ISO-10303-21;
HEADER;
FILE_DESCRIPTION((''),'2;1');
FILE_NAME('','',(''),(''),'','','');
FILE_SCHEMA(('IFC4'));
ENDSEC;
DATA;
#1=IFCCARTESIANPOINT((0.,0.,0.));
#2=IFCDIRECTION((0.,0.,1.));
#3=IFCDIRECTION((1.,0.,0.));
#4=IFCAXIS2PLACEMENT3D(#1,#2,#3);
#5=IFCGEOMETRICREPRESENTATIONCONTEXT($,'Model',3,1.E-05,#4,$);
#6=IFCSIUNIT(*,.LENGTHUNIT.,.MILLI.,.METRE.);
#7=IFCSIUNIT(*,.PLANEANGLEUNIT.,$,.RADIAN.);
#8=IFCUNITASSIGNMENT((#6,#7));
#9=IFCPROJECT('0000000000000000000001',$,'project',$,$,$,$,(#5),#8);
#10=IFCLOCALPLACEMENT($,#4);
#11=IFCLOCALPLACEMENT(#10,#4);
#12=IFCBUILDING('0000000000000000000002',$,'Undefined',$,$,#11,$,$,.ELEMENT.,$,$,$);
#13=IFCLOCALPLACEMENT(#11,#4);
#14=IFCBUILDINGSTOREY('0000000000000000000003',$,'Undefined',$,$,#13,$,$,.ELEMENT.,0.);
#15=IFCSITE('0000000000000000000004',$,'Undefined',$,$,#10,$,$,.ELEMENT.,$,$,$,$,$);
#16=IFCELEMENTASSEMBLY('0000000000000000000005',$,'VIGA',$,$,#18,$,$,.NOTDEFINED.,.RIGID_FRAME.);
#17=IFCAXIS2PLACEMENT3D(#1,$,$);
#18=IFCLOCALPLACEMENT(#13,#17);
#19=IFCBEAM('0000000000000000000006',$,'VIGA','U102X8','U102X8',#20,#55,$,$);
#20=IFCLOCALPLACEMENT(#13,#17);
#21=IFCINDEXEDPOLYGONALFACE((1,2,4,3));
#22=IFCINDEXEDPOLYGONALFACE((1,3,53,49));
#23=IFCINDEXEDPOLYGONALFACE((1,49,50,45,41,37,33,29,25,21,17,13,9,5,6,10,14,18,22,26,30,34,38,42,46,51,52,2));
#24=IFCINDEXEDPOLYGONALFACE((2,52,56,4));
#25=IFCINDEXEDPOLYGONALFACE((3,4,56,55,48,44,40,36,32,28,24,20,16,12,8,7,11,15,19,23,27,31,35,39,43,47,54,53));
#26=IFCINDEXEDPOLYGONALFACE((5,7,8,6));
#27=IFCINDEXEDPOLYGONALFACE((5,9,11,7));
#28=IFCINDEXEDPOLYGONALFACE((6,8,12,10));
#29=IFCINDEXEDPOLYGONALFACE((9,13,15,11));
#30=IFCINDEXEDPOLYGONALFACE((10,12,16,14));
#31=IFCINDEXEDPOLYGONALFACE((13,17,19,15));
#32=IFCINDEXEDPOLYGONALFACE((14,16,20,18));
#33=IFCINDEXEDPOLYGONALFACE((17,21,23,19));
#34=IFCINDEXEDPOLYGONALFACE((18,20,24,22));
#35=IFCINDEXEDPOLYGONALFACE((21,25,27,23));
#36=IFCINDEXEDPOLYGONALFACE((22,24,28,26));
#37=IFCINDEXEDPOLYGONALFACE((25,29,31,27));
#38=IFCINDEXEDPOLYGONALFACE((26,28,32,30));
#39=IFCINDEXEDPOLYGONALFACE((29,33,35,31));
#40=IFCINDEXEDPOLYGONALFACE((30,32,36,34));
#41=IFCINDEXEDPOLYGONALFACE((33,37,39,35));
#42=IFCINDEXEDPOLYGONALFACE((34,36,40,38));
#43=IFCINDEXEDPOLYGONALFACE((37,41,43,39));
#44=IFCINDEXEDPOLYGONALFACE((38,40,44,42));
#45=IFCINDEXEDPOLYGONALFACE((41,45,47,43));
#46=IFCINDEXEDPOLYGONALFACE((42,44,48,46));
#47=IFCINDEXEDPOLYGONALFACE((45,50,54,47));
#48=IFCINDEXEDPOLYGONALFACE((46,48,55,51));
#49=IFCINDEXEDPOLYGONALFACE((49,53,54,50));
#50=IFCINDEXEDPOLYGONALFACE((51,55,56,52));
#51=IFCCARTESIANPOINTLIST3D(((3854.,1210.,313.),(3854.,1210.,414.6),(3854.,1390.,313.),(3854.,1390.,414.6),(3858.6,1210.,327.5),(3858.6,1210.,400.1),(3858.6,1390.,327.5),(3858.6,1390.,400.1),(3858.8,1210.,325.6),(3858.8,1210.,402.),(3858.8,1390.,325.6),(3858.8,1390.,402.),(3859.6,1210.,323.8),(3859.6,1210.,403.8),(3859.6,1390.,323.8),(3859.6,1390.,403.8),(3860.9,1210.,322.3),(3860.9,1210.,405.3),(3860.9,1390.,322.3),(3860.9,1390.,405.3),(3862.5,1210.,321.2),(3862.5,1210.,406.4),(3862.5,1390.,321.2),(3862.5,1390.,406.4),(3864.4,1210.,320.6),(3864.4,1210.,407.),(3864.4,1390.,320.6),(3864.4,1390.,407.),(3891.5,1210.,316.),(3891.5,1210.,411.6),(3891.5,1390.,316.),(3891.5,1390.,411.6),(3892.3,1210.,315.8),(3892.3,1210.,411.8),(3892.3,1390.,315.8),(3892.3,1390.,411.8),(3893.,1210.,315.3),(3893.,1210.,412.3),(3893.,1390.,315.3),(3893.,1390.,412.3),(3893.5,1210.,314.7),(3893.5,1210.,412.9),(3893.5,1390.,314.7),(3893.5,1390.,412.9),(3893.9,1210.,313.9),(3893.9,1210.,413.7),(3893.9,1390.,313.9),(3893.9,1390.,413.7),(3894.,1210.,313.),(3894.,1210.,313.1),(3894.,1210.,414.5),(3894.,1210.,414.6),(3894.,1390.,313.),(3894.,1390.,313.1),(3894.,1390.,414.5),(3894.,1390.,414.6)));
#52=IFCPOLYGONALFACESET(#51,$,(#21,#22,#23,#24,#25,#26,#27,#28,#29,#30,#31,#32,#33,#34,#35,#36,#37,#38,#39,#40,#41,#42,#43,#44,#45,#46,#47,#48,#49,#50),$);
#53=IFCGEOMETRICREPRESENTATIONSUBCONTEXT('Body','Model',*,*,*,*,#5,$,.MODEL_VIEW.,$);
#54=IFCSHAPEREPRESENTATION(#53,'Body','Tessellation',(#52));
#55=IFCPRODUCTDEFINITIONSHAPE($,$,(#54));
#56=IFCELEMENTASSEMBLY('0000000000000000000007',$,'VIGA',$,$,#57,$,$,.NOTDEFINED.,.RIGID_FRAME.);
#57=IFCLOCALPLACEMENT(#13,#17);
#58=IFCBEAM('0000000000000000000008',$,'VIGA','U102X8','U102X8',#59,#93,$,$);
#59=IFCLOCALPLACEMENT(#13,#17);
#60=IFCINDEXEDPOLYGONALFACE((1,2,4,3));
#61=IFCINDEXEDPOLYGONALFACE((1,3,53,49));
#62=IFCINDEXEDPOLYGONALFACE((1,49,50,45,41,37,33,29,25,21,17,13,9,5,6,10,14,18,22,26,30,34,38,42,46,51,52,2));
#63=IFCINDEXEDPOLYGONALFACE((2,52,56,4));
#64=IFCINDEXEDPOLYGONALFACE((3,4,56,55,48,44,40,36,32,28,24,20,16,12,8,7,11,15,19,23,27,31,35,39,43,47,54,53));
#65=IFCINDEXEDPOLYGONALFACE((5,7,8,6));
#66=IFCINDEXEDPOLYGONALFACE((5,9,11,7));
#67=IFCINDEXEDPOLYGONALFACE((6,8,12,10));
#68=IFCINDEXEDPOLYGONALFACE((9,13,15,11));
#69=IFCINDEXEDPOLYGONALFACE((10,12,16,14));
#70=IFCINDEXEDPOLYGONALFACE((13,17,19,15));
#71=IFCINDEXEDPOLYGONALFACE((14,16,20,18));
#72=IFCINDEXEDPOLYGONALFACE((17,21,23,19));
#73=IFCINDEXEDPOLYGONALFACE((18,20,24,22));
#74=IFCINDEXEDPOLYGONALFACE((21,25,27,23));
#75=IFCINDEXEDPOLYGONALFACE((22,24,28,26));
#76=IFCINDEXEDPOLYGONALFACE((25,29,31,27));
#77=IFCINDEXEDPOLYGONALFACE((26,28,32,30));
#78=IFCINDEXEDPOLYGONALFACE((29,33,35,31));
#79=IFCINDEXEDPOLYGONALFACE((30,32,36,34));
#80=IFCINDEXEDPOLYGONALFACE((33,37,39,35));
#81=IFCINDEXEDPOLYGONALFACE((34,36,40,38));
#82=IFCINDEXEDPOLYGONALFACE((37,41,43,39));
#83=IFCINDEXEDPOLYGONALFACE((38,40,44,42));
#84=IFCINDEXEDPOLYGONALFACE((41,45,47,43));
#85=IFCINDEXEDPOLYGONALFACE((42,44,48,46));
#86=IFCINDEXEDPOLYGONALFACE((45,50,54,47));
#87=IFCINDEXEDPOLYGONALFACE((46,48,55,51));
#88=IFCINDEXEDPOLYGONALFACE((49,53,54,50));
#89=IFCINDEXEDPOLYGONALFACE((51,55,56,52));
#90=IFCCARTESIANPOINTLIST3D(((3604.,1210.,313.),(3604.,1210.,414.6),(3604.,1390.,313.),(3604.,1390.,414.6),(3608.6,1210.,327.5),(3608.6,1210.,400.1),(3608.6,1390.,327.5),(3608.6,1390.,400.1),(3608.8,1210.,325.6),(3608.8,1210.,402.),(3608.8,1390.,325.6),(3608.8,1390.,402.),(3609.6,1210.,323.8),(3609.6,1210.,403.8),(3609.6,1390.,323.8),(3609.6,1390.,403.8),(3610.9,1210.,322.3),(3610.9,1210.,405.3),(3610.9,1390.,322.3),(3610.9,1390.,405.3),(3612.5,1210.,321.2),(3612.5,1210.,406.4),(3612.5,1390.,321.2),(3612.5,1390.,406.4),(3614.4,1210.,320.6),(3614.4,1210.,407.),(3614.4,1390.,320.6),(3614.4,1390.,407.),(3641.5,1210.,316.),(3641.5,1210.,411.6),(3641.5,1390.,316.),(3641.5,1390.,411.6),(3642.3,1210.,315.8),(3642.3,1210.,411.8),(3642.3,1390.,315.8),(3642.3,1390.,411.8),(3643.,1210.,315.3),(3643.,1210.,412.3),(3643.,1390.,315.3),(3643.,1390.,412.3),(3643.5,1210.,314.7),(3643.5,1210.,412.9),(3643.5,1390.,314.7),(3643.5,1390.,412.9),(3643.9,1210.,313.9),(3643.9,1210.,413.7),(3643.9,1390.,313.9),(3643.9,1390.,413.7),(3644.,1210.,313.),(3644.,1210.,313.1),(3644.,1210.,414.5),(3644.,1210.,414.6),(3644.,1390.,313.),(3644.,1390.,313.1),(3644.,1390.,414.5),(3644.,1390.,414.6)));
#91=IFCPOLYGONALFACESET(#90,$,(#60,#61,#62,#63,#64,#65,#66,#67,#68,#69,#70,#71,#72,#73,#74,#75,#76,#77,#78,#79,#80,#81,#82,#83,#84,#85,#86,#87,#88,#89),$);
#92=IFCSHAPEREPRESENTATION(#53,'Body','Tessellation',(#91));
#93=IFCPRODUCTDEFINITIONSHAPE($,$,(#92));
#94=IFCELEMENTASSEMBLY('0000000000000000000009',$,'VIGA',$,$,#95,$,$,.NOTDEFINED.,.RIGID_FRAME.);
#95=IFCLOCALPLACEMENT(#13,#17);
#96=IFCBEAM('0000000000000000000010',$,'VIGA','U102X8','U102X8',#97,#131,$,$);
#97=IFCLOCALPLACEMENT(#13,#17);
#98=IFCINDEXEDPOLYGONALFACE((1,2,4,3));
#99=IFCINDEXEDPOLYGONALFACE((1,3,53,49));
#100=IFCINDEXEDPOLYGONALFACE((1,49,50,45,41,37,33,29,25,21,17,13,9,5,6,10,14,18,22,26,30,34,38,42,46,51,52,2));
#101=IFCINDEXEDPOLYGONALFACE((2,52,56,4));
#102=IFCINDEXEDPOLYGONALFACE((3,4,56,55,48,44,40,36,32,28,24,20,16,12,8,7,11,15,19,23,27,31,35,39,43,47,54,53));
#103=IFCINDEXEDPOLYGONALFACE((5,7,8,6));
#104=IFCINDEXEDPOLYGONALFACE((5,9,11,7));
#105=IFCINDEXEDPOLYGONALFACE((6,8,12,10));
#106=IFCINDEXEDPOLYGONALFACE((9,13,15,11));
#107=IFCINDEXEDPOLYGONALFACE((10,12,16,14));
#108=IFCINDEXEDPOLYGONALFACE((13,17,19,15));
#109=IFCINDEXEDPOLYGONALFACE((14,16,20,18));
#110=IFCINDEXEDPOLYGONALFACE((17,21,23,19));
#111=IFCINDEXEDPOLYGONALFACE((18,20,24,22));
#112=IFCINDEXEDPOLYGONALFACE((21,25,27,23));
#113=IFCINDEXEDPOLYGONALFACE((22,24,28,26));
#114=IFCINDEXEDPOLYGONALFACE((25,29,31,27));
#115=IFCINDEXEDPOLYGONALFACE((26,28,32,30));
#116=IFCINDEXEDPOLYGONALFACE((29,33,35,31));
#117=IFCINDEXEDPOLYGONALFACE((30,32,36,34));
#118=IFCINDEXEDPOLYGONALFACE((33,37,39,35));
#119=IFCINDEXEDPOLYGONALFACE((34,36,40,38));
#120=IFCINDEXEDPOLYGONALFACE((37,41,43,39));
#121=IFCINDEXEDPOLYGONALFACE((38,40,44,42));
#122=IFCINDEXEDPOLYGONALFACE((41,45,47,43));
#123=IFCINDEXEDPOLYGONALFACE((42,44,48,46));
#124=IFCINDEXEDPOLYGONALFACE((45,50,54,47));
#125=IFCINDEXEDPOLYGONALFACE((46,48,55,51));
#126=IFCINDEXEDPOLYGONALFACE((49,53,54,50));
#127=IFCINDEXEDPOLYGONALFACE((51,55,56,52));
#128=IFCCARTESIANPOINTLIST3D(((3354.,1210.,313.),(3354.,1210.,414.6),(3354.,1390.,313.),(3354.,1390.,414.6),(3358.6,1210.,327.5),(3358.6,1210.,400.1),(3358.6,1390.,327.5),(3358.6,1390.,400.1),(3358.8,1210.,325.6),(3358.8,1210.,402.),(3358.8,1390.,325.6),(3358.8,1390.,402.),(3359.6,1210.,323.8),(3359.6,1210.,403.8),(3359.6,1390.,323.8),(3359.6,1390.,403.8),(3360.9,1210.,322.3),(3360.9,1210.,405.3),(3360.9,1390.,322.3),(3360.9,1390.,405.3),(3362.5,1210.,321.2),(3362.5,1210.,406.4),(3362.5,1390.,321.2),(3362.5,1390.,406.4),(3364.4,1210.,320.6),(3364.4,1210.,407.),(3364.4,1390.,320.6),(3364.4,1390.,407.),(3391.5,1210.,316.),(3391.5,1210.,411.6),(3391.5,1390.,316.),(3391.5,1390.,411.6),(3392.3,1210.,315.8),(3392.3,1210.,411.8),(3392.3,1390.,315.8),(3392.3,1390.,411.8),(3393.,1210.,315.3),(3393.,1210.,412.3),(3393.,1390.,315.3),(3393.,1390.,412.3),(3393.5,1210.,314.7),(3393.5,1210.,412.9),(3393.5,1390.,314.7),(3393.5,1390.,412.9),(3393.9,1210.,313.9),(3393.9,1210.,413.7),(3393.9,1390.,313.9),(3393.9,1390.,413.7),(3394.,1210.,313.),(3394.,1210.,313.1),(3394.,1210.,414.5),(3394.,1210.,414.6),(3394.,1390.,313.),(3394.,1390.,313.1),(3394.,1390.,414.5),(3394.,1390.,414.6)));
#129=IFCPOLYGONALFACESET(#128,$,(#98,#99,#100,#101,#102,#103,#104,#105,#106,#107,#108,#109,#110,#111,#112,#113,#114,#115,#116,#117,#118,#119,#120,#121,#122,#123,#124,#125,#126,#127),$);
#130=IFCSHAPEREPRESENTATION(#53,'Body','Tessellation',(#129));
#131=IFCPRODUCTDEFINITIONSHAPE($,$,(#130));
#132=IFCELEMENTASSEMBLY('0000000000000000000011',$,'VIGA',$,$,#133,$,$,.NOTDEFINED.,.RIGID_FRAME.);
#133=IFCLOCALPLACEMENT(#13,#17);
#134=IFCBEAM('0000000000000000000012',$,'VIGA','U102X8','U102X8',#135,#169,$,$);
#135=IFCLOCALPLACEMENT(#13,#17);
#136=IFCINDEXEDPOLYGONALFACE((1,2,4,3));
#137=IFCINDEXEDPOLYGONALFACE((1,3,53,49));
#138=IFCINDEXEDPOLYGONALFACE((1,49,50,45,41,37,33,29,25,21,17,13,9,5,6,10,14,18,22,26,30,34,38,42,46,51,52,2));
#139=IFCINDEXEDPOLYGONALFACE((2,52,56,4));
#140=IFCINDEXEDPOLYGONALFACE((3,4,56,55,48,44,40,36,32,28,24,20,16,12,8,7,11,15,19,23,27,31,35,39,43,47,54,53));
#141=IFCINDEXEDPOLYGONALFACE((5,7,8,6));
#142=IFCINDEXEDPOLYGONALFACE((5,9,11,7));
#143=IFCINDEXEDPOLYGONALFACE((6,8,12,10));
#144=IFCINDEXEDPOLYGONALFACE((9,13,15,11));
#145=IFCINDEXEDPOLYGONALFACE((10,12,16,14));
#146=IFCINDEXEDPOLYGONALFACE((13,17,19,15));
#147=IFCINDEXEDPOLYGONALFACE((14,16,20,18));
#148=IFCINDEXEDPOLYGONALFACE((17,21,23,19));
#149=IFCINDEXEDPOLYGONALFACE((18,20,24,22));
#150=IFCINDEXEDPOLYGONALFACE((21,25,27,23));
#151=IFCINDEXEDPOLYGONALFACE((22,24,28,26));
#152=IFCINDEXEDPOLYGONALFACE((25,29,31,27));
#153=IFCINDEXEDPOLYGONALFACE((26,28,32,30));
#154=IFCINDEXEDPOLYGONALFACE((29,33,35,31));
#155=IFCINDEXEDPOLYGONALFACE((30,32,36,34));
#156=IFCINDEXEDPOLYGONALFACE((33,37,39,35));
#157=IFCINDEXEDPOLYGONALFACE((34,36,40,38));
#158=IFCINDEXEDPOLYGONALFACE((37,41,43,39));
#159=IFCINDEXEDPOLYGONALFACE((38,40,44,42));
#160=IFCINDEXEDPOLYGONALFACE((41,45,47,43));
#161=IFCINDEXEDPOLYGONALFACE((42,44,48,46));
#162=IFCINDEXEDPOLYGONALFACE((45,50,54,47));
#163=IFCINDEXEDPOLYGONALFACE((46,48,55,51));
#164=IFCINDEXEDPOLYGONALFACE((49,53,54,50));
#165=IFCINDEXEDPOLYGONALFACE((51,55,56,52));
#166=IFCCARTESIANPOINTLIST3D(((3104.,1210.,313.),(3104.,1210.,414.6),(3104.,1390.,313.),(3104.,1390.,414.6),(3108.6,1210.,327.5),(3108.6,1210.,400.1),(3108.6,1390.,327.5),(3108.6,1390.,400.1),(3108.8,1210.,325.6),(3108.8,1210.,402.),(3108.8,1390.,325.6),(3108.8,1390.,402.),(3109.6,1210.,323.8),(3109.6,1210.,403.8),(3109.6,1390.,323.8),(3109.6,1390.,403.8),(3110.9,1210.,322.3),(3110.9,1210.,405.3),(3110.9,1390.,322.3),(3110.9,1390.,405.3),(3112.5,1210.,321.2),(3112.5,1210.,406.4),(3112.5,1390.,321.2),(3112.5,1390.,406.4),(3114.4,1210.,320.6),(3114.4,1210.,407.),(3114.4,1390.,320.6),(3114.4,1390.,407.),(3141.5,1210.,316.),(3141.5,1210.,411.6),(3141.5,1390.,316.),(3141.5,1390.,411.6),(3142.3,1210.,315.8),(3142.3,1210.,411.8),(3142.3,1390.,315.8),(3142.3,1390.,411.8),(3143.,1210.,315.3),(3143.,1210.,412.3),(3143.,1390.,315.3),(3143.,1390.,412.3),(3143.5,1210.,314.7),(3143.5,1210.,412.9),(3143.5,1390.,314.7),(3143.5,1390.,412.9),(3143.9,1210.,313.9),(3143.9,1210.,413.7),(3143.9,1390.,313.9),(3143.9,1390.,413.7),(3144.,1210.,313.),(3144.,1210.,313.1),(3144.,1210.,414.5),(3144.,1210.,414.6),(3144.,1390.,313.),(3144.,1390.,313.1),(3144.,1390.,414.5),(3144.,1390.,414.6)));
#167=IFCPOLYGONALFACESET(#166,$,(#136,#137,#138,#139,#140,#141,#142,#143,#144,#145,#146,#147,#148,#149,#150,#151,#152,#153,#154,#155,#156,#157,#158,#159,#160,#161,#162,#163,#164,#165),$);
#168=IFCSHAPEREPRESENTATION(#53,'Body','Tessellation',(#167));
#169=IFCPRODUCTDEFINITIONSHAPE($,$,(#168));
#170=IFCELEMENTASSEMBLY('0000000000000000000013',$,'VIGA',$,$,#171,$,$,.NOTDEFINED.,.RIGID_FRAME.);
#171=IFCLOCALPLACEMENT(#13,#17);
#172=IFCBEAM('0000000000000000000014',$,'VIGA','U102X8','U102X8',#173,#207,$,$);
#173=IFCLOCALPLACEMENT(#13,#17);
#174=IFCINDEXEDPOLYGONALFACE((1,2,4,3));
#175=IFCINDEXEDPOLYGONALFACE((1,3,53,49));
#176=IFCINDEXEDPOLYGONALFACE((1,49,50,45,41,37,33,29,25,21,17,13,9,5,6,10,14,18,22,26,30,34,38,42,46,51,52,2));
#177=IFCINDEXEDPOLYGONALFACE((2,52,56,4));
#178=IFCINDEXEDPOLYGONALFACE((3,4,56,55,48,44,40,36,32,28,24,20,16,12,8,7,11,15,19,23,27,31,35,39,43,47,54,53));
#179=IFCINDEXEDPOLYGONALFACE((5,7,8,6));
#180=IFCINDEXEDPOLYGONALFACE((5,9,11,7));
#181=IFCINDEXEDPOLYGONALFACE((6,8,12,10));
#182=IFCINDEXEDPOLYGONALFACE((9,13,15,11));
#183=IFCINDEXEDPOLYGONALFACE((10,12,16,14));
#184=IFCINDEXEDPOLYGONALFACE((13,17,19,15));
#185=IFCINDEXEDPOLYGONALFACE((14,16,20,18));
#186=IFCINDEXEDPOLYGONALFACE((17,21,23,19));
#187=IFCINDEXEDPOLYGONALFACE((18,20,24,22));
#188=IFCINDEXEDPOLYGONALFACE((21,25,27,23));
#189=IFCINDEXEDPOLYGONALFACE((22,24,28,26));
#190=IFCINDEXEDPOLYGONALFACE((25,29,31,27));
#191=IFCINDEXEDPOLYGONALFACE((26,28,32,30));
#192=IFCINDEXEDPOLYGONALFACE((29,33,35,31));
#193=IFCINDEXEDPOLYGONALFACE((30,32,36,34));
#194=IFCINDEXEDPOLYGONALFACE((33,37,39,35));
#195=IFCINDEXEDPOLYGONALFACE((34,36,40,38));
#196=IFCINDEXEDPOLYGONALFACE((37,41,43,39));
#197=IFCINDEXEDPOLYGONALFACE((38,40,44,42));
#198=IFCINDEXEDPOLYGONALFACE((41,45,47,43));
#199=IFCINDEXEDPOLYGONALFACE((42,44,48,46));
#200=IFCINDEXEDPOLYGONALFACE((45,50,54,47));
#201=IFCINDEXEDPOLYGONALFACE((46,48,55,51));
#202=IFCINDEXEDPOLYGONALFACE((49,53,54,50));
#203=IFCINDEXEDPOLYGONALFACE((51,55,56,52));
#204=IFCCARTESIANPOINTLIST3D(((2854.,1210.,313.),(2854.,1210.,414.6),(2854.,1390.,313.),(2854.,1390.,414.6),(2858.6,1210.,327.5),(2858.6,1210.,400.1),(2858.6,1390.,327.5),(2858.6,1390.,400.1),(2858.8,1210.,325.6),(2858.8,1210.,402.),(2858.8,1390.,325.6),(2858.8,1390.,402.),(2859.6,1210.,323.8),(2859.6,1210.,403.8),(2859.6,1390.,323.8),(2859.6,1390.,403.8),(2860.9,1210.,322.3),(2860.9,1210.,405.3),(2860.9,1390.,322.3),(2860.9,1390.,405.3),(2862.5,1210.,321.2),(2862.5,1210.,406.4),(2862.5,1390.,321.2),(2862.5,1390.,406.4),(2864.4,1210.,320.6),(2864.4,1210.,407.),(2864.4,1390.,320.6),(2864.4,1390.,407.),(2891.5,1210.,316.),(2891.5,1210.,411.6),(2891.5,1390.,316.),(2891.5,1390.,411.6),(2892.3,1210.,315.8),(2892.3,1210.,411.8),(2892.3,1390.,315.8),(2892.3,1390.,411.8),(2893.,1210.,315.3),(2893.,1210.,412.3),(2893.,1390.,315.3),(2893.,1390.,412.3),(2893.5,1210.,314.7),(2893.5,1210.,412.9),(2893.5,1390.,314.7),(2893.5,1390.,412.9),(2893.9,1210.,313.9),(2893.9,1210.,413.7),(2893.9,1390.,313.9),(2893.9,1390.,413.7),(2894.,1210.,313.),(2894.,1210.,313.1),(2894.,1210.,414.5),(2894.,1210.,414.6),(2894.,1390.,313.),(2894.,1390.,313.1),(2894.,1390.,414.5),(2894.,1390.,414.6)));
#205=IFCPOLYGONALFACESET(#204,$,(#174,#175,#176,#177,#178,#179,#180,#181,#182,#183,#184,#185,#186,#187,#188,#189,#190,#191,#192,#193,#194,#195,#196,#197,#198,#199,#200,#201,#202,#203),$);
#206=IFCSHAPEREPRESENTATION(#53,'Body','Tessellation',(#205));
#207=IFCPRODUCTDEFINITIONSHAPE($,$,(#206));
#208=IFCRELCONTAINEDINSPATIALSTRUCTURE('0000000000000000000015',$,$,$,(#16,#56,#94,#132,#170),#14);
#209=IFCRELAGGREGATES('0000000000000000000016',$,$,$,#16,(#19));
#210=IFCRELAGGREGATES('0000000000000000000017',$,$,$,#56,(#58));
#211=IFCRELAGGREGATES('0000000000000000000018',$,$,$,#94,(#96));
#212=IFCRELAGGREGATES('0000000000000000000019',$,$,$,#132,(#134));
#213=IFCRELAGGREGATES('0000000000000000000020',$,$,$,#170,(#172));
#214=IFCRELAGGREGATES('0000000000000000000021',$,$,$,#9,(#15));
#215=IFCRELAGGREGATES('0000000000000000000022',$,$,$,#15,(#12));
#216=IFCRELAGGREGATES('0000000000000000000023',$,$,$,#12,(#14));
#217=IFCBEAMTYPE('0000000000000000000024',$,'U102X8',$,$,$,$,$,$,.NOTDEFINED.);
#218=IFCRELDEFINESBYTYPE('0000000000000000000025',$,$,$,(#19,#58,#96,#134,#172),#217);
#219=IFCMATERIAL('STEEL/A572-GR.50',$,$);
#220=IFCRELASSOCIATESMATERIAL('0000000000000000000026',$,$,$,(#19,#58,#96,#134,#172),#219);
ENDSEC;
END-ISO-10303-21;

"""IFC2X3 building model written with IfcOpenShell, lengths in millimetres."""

from ifc_helpers import new_model, si_unit, frame, origin_with_axes, origin_2d_with_axis, place, context, subcontext, project, spatial, u_section, extrude, material, type_object, element, aggregate, save


model = new_model("IFC2X3")

# Units and contexts
model_context = context("Model", 3, precision=1e-05, world=origin_with_axes())
body_context = subcontext(model_context, "Body", "Model", "MODEL_VIEW")
ifc_project = project(units=[si_unit("LENGTHUNIT", "METRE", prefix="MILLI"), si_unit("PLANEANGLEUNIT", "RADIAN")], contexts=[model_context])

# Site, building, storey
site_placement = place(None, origin_with_axes())
site = spatial("IfcSite", under=ifc_project, at=site_placement, Name="Undefined", CompositionType="ELEMENT")
building_placement = place(site_placement, origin_with_axes())
building = spatial("IfcBuilding", under=site, at=building_placement, Name="Undefined", CompositionType="ELEMENT")
storey_placement = place(building_placement, origin_with_axes())
storey = spatial("IfcBuildingStorey", under=building, at=storey_placement, Name="Undefined", CompositionType="ELEMENT", Elevation=0.0)

# Element assemblies, beams
assembly_1_placement = place(storey_placement, origin_with_axes())
assembly_1 = element("IfcElementAssembly", 1, at=assembly_1_placement, inside=storey, Name="VIGA", AssemblyPlace="NOTDEFINED", PredefinedType="RIGID_FRAME")
ifc_material = material(Name="STEEL/A572-GR.50")
beam_type = type_object("IfcBeamType", Name="U102X8", PredefinedType="NOTDEFINED")
beam_1_placement = place(assembly_1_placement, frame((3874.0, 1210.0, 363.8), z_axis=(0.0, 0.0, 1.0), x_axis=(0.0, 1.0, 0.0)))
beam_1 = element("IfcBeam", 2, at=beam_1_placement, type_object=beam_type, material=ifc_material, Name="VIGA", Description="U102X8", ObjectType="U102X8", context=body_context, shape_type="SweptSolid", body=[
    extrude(u_section(Depth=101.6, FlangeWidth=40.0, WebThickness=4.6, FlangeThickness=6.0, FilletRadius=7.0, EdgeRadius=3.0, FlangeSlope=0.16839, at=origin_2d_with_axis()), frame((180.0, 0.0, 0.0), z_axis=(-1.0, 0.0, 0.0), x_axis=(0.0, -1.0, 0.0)), (0.0, 0.0, 1.0), 180.0),
])
aggregate(assembly_1, [beam_1])
assembly_2_placement = place(storey_placement, origin_with_axes())
assembly_2 = element("IfcElementAssembly", 3, at=assembly_2_placement, inside=storey, Name="VIGA", AssemblyPlace="NOTDEFINED", PredefinedType="RIGID_FRAME")
beam_2_placement = place(assembly_2_placement, frame((3624.0, 1210.0, 363.8), z_axis=(0.0, 0.0, 1.0), x_axis=(0.0, 1.0, 0.0)))
beam_2 = element("IfcBeam", 4, at=beam_2_placement, type_object=beam_type, material=ifc_material, Name="VIGA", Description="U102X8", ObjectType="U102X8", context=body_context, shape_type="SweptSolid", body=[
    extrude(u_section(Depth=101.6, FlangeWidth=40.0, WebThickness=4.6, FlangeThickness=6.0, FilletRadius=7.0, EdgeRadius=3.0, FlangeSlope=0.16839, at=origin_2d_with_axis()), frame((180.0, 0.0, 0.0), z_axis=(-1.0, 0.0, 0.0), x_axis=(0.0, -1.0, 0.0)), (0.0, 0.0, 1.0), 180.0),
])
aggregate(assembly_2, [beam_2])
assembly_3_placement = place(storey_placement, origin_with_axes())
assembly_3 = element("IfcElementAssembly", 5, at=assembly_3_placement, inside=storey, Name="VIGA", AssemblyPlace="NOTDEFINED", PredefinedType="RIGID_FRAME")
beam_3_placement = place(assembly_3_placement, frame((3374.0, 1210.0, 363.8), z_axis=(0.0, 0.0, 1.0), x_axis=(0.0, 1.0, 0.0)))
beam_3 = element("IfcBeam", 6, at=beam_3_placement, type_object=beam_type, material=ifc_material, Name="VIGA", Description="U102X8", ObjectType="U102X8", context=body_context, shape_type="SweptSolid", body=[
    extrude(u_section(Depth=101.6, FlangeWidth=40.0, WebThickness=4.6, FlangeThickness=6.0, FilletRadius=7.0, EdgeRadius=3.0, FlangeSlope=0.16839, at=origin_2d_with_axis()), frame((180.0, 0.0, 0.0), z_axis=(-1.0, 0.0, 0.0), x_axis=(0.0, -1.0, 0.0)), (0.0, 0.0, 1.0), 180.0),
])
aggregate(assembly_3, [beam_3])
assembly_4_placement = place(storey_placement, origin_with_axes())
assembly_4 = element("IfcElementAssembly", 7, at=assembly_4_placement, inside=storey, Name="VIGA", AssemblyPlace="NOTDEFINED", PredefinedType="RIGID_FRAME")
beam_4_placement = place(assembly_4_placement, frame((3124.0, 1210.0, 363.8), z_axis=(0.0, 0.0, 1.0), x_axis=(0.0, 1.0, 0.0)))
beam_4 = element("IfcBeam", 8, at=beam_4_placement, type_object=beam_type, material=ifc_material, Name="VIGA", Description="U102X8", ObjectType="U102X8", context=body_context, shape_type="SweptSolid", body=[
    extrude(u_section(Depth=101.6, FlangeWidth=40.0, WebThickness=4.6, FlangeThickness=6.0, FilletRadius=7.0, EdgeRadius=3.0, FlangeSlope=0.16839, at=origin_2d_with_axis()), frame((180.0, 0.0, 0.0), z_axis=(-1.0, 0.0, 0.0), x_axis=(0.0, -1.0, 0.0)), (0.0, 0.0, 1.0), 180.0),
])
aggregate(assembly_4, [beam_4])
assembly_5_placement = place(storey_placement, origin_with_axes())
assembly_5 = element("IfcElementAssembly", 9, at=assembly_5_placement, inside=storey, Name="VIGA", AssemblyPlace="NOTDEFINED", PredefinedType="RIGID_FRAME")
beam_5_placement = place(assembly_5_placement, frame((2874.0, 1210.0, 363.8), z_axis=(0.0, 0.0, 1.0), x_axis=(0.0, 1.0, 0.0)))
beam_5 = element("IfcBeam", 10, at=beam_5_placement, type_object=beam_type, material=ifc_material, Name="VIGA", Description="U102X8", ObjectType="U102X8", context=body_context, shape_type="SweptSolid", body=[
    extrude(u_section(Depth=101.6, FlangeWidth=40.0, WebThickness=4.6, FlangeThickness=6.0, FilletRadius=7.0, EdgeRadius=3.0, FlangeSlope=0.16839, at=origin_2d_with_axis()), frame((180.0, 0.0, 0.0), z_axis=(-1.0, 0.0, 0.0), x_axis=(0.0, -1.0, 0.0)), (0.0, 0.0, 1.0), 180.0),
])
aggregate(assembly_5, [beam_5])

save(model, "model.ifc")
